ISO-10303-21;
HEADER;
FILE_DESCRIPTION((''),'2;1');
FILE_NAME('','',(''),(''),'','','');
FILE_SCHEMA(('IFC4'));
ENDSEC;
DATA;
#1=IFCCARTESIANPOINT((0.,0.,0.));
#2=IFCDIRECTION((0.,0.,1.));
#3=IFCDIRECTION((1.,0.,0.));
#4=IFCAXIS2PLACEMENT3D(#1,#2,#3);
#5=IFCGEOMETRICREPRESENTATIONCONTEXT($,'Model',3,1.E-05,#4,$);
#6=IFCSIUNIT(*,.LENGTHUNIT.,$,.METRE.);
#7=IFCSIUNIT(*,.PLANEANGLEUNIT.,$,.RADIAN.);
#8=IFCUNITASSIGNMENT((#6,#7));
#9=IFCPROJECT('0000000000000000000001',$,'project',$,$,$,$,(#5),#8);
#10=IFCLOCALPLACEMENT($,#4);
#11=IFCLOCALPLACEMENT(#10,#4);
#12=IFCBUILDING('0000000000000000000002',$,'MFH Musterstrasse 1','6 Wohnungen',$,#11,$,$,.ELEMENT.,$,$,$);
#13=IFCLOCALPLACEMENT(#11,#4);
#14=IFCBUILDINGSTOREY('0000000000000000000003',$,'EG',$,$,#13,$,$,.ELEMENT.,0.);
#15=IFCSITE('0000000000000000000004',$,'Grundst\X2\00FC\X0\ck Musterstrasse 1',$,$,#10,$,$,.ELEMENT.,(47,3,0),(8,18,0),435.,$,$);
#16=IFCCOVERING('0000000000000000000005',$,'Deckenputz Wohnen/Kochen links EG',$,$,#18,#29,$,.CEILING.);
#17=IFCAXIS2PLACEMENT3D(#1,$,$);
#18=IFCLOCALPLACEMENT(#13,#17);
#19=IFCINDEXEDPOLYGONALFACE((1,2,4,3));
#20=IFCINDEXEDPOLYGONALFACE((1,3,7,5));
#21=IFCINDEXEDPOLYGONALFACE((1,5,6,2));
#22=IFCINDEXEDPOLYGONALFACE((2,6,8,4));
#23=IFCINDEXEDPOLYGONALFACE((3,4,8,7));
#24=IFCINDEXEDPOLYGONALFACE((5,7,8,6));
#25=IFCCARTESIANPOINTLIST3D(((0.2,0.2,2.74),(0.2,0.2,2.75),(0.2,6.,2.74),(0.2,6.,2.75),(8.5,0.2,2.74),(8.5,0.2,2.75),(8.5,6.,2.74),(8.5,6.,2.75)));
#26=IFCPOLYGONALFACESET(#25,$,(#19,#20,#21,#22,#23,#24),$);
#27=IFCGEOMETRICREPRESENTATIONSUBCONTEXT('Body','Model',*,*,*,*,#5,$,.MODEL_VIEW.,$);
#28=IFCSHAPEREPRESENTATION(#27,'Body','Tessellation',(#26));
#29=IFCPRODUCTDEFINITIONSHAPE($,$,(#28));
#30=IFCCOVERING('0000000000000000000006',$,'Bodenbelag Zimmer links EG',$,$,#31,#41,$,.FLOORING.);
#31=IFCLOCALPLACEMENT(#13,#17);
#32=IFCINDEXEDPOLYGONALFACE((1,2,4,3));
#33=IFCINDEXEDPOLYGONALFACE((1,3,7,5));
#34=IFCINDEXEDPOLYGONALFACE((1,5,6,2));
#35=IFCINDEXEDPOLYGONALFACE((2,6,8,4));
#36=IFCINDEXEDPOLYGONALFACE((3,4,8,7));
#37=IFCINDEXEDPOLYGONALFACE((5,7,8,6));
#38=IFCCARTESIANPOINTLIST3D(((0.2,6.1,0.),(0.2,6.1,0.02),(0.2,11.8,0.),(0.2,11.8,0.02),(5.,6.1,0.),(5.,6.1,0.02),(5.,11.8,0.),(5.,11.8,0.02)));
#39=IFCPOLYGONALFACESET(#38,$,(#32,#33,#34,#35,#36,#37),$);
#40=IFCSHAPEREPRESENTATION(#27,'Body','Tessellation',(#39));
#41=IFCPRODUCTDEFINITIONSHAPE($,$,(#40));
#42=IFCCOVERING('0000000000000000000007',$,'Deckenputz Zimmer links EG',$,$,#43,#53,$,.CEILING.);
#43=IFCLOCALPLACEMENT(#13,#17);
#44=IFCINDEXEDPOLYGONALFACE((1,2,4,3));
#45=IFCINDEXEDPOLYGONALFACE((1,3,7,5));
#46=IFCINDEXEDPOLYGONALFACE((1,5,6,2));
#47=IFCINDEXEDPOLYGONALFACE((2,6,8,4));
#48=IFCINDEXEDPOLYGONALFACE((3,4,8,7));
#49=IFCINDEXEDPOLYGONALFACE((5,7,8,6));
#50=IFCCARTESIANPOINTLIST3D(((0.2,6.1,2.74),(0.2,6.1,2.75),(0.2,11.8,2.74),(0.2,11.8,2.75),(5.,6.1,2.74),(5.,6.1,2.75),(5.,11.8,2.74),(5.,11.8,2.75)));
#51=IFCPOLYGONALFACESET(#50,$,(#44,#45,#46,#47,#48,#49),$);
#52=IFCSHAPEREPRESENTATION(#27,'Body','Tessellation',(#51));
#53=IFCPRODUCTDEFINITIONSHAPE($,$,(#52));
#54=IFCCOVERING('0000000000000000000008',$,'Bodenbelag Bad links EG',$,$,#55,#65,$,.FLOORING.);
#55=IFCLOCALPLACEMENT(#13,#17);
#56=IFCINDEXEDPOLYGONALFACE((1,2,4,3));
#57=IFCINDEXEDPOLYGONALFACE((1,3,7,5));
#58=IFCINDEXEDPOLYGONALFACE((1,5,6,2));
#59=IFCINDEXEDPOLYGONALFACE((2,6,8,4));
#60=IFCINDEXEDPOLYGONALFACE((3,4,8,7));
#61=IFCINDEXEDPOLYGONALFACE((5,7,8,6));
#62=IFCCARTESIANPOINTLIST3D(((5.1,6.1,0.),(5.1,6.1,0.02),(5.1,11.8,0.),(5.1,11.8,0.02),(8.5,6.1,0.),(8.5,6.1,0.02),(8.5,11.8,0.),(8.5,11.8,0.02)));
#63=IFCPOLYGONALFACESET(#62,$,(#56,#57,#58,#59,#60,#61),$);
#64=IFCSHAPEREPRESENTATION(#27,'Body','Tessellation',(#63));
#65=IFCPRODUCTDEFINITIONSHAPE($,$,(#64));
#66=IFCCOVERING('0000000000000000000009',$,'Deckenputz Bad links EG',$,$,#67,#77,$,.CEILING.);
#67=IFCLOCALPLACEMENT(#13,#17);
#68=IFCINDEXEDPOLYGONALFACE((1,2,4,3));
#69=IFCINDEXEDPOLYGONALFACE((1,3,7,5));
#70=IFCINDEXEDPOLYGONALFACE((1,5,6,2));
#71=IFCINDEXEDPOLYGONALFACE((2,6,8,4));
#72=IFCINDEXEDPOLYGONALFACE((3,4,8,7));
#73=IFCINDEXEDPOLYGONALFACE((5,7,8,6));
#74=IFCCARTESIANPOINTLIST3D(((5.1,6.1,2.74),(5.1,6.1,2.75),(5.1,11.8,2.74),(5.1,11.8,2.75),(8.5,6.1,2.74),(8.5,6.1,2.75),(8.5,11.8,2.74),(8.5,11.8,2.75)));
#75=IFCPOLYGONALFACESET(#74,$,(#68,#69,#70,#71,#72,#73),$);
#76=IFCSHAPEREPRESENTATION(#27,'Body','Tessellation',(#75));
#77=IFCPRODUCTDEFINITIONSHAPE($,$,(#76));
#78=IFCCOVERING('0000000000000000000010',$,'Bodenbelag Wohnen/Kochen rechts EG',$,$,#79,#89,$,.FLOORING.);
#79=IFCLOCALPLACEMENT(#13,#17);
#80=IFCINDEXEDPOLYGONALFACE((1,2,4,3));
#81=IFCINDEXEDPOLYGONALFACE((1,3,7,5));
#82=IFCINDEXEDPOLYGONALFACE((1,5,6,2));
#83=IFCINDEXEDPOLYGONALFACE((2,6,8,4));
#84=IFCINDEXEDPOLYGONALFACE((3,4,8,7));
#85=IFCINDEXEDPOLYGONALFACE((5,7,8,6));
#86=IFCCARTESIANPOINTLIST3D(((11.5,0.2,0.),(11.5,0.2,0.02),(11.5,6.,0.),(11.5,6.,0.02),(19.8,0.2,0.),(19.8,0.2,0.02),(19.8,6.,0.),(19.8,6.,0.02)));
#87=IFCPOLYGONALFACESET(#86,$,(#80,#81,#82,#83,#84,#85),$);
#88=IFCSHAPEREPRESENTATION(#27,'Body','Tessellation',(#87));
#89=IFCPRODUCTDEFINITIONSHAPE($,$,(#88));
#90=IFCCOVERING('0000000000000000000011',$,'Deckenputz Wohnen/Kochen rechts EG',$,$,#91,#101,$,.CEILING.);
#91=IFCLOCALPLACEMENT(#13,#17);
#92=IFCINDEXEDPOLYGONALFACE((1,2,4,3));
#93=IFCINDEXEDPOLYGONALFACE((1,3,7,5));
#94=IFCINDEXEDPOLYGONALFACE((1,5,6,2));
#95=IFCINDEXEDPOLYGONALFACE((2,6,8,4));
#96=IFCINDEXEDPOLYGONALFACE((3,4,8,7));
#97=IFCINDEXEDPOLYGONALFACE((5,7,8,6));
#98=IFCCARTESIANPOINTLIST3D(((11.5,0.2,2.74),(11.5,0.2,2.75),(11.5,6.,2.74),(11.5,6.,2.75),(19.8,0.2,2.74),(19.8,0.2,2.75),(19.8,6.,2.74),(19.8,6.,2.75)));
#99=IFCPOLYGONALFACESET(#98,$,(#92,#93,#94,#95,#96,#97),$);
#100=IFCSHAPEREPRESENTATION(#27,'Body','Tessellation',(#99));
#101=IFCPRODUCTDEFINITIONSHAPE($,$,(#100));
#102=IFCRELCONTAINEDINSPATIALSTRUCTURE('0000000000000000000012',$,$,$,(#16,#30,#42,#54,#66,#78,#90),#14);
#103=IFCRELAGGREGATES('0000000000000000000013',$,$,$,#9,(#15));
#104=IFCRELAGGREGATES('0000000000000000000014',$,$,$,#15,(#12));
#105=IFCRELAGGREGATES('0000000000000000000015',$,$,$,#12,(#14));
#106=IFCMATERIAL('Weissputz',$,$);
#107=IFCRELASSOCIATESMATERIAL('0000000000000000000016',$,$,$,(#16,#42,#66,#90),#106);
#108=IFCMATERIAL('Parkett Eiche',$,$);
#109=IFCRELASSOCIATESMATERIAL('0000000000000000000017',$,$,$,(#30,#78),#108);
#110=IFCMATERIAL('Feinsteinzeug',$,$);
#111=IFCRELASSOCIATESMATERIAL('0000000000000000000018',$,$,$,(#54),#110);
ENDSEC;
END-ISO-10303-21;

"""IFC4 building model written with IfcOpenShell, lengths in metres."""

from ifc_helpers import new_model, si_unit, frame, frame_2d, origin_with_axes, place, context, subcontext, project, spatial, rectangle, extrude, material, element, save


model = new_model("IFC4")

# Units and contexts
model_context = context("Model", 3, precision=1e-05, world=origin_with_axes())
body_context = subcontext(model_context, "Body", "Model", "MODEL_VIEW")
ifc_project = project(units=[si_unit("LENGTHUNIT", "METRE"), si_unit("PLANEANGLEUNIT", "RADIAN")], contexts=[model_context])

# Site, building, storey
site_placement = place(None, origin_with_axes())
site = spatial("IfcSite", under=ifc_project, at=site_placement, Name="Grundstück Musterstrasse 1", CompositionType="ELEMENT", RefLatitude=(47, 3, 0), RefLongitude=(8, 18, 0), RefElevation=435.0)
building_placement = place(site_placement, origin_with_axes())
building = spatial("IfcBuilding", under=site, at=building_placement, Name="MFH Musterstrasse 1", Description="6 Wohnungen", CompositionType="ELEMENT")
storey_placement = place(building_placement, origin_with_axes())
storey = spatial("IfcBuildingStorey", under=building, at=storey_placement, Name="EG", CompositionType="ELEMENT", Elevation=0.0)

# Coverings
ifc_material_1 = material(Name="Parkett Eiche")
ifc_material_2 = material(Name="Weissputz")
covering_1_placement = place(storey_placement, origin_with_axes())
element("IfcCovering", 1, at=covering_1_placement, inside=storey, material=ifc_material_2, Name="Deckenputz Wohnen/Kochen links EG", PredefinedType="CEILING", context=body_context, shape_type="SweptSolid", body=[
    extrude(rectangle(XDim=8.3, YDim=5.8, at=frame_2d((4.15, 2.9), x_axis=(1.0, 0.0))), frame((0.2, 0.2, 2.74), z_axis=(0.0, 0.0, 1.0), x_axis=(1.0, 0.0, 0.0)), (0.0, 0.0, 1.0), 0.01),
])
covering_2_placement = place(storey_placement, origin_with_axes())
element("IfcCovering", 2, at=covering_2_placement, inside=storey, material=ifc_material_1, Name="Bodenbelag Zimmer links EG", PredefinedType="FLOORING", context=body_context, shape_type="SweptSolid", body=[
    extrude(rectangle(XDim=4.8, YDim=5.7, at=frame_2d((2.4, 2.85), x_axis=(1.0, 0.0))), frame((0.2, 6.1, 0.0), z_axis=(0.0, 0.0, 1.0), x_axis=(1.0, 0.0, 0.0)), (0.0, 0.0, 1.0), 0.02),
])
covering_3_placement = place(storey_placement, origin_with_axes())
element("IfcCovering", 3, at=covering_3_placement, inside=storey, material=ifc_material_2, Name="Deckenputz Zimmer links EG", PredefinedType="CEILING", context=body_context, shape_type="SweptSolid", body=[
    extrude(rectangle(XDim=4.8, YDim=5.7, at=frame_2d((2.4, 2.85), x_axis=(1.0, 0.0))), frame((0.2, 6.1, 2.74), z_axis=(0.0, 0.0, 1.0), x_axis=(1.0, 0.0, 0.0)), (0.0, 0.0, 1.0), 0.01),
])
ifc_material_3 = material(Name="Feinsteinzeug")
covering_4_placement = place(storey_placement, origin_with_axes())
element("IfcCovering", 4, at=covering_4_placement, inside=storey, material=ifc_material_3, Name="Bodenbelag Bad links EG", PredefinedType="FLOORING", context=body_context, shape_type="SweptSolid", body=[
    extrude(rectangle(XDim=3.4, YDim=5.7, at=frame_2d((1.7, 2.85), x_axis=(1.0, 0.0))), frame((5.1, 6.1, 0.0), z_axis=(0.0, 0.0, 1.0), x_axis=(1.0, 0.0, 0.0)), (0.0, 0.0, 1.0), 0.02),
])
covering_5_placement = place(storey_placement, origin_with_axes())
element("IfcCovering", 5, at=covering_5_placement, inside=storey, material=ifc_material_2, Name="Deckenputz Bad links EG", PredefinedType="CEILING", context=body_context, shape_type="SweptSolid", body=[
    extrude(rectangle(XDim=3.4, YDim=5.7, at=frame_2d((1.7, 2.85), x_axis=(1.0, 0.0))), frame((5.1, 6.1, 2.74), z_axis=(0.0, 0.0, 1.0), x_axis=(1.0, 0.0, 0.0)), (0.0, 0.0, 1.0), 0.01),
])
covering_6_placement = place(storey_placement, origin_with_axes())
element("IfcCovering", 6, at=covering_6_placement, inside=storey, material=ifc_material_1, Name="Bodenbelag Wohnen/Kochen rechts EG", PredefinedType="FLOORING", context=body_context, shape_type="SweptSolid", body=[
    extrude(rectangle(XDim=8.3, YDim=5.8, at=frame_2d((4.15, 2.9), x_axis=(1.0, 0.0))), frame((11.5, 0.2, 0.0), z_axis=(0.0, 0.0, 1.0), x_axis=(1.0, 0.0, 0.0)), (0.0, 0.0, 1.0), 0.02),
])
covering_7_placement = place(storey_placement, origin_with_axes())
element("IfcCovering", 7, at=covering_7_placement, inside=storey, material=ifc_material_2, Name="Deckenputz Wohnen/Kochen rechts EG", PredefinedType="CEILING", context=body_context, shape_type="SweptSolid", body=[
    extrude(rectangle(XDim=8.3, YDim=5.8, at=frame_2d((4.15, 2.9), x_axis=(1.0, 0.0))), frame((11.5, 0.2, 2.74), z_axis=(0.0, 0.0, 1.0), x_axis=(1.0, 0.0, 0.0)), (0.0, 0.0, 1.0), 0.01),
])

save(model, "model.ifc")
